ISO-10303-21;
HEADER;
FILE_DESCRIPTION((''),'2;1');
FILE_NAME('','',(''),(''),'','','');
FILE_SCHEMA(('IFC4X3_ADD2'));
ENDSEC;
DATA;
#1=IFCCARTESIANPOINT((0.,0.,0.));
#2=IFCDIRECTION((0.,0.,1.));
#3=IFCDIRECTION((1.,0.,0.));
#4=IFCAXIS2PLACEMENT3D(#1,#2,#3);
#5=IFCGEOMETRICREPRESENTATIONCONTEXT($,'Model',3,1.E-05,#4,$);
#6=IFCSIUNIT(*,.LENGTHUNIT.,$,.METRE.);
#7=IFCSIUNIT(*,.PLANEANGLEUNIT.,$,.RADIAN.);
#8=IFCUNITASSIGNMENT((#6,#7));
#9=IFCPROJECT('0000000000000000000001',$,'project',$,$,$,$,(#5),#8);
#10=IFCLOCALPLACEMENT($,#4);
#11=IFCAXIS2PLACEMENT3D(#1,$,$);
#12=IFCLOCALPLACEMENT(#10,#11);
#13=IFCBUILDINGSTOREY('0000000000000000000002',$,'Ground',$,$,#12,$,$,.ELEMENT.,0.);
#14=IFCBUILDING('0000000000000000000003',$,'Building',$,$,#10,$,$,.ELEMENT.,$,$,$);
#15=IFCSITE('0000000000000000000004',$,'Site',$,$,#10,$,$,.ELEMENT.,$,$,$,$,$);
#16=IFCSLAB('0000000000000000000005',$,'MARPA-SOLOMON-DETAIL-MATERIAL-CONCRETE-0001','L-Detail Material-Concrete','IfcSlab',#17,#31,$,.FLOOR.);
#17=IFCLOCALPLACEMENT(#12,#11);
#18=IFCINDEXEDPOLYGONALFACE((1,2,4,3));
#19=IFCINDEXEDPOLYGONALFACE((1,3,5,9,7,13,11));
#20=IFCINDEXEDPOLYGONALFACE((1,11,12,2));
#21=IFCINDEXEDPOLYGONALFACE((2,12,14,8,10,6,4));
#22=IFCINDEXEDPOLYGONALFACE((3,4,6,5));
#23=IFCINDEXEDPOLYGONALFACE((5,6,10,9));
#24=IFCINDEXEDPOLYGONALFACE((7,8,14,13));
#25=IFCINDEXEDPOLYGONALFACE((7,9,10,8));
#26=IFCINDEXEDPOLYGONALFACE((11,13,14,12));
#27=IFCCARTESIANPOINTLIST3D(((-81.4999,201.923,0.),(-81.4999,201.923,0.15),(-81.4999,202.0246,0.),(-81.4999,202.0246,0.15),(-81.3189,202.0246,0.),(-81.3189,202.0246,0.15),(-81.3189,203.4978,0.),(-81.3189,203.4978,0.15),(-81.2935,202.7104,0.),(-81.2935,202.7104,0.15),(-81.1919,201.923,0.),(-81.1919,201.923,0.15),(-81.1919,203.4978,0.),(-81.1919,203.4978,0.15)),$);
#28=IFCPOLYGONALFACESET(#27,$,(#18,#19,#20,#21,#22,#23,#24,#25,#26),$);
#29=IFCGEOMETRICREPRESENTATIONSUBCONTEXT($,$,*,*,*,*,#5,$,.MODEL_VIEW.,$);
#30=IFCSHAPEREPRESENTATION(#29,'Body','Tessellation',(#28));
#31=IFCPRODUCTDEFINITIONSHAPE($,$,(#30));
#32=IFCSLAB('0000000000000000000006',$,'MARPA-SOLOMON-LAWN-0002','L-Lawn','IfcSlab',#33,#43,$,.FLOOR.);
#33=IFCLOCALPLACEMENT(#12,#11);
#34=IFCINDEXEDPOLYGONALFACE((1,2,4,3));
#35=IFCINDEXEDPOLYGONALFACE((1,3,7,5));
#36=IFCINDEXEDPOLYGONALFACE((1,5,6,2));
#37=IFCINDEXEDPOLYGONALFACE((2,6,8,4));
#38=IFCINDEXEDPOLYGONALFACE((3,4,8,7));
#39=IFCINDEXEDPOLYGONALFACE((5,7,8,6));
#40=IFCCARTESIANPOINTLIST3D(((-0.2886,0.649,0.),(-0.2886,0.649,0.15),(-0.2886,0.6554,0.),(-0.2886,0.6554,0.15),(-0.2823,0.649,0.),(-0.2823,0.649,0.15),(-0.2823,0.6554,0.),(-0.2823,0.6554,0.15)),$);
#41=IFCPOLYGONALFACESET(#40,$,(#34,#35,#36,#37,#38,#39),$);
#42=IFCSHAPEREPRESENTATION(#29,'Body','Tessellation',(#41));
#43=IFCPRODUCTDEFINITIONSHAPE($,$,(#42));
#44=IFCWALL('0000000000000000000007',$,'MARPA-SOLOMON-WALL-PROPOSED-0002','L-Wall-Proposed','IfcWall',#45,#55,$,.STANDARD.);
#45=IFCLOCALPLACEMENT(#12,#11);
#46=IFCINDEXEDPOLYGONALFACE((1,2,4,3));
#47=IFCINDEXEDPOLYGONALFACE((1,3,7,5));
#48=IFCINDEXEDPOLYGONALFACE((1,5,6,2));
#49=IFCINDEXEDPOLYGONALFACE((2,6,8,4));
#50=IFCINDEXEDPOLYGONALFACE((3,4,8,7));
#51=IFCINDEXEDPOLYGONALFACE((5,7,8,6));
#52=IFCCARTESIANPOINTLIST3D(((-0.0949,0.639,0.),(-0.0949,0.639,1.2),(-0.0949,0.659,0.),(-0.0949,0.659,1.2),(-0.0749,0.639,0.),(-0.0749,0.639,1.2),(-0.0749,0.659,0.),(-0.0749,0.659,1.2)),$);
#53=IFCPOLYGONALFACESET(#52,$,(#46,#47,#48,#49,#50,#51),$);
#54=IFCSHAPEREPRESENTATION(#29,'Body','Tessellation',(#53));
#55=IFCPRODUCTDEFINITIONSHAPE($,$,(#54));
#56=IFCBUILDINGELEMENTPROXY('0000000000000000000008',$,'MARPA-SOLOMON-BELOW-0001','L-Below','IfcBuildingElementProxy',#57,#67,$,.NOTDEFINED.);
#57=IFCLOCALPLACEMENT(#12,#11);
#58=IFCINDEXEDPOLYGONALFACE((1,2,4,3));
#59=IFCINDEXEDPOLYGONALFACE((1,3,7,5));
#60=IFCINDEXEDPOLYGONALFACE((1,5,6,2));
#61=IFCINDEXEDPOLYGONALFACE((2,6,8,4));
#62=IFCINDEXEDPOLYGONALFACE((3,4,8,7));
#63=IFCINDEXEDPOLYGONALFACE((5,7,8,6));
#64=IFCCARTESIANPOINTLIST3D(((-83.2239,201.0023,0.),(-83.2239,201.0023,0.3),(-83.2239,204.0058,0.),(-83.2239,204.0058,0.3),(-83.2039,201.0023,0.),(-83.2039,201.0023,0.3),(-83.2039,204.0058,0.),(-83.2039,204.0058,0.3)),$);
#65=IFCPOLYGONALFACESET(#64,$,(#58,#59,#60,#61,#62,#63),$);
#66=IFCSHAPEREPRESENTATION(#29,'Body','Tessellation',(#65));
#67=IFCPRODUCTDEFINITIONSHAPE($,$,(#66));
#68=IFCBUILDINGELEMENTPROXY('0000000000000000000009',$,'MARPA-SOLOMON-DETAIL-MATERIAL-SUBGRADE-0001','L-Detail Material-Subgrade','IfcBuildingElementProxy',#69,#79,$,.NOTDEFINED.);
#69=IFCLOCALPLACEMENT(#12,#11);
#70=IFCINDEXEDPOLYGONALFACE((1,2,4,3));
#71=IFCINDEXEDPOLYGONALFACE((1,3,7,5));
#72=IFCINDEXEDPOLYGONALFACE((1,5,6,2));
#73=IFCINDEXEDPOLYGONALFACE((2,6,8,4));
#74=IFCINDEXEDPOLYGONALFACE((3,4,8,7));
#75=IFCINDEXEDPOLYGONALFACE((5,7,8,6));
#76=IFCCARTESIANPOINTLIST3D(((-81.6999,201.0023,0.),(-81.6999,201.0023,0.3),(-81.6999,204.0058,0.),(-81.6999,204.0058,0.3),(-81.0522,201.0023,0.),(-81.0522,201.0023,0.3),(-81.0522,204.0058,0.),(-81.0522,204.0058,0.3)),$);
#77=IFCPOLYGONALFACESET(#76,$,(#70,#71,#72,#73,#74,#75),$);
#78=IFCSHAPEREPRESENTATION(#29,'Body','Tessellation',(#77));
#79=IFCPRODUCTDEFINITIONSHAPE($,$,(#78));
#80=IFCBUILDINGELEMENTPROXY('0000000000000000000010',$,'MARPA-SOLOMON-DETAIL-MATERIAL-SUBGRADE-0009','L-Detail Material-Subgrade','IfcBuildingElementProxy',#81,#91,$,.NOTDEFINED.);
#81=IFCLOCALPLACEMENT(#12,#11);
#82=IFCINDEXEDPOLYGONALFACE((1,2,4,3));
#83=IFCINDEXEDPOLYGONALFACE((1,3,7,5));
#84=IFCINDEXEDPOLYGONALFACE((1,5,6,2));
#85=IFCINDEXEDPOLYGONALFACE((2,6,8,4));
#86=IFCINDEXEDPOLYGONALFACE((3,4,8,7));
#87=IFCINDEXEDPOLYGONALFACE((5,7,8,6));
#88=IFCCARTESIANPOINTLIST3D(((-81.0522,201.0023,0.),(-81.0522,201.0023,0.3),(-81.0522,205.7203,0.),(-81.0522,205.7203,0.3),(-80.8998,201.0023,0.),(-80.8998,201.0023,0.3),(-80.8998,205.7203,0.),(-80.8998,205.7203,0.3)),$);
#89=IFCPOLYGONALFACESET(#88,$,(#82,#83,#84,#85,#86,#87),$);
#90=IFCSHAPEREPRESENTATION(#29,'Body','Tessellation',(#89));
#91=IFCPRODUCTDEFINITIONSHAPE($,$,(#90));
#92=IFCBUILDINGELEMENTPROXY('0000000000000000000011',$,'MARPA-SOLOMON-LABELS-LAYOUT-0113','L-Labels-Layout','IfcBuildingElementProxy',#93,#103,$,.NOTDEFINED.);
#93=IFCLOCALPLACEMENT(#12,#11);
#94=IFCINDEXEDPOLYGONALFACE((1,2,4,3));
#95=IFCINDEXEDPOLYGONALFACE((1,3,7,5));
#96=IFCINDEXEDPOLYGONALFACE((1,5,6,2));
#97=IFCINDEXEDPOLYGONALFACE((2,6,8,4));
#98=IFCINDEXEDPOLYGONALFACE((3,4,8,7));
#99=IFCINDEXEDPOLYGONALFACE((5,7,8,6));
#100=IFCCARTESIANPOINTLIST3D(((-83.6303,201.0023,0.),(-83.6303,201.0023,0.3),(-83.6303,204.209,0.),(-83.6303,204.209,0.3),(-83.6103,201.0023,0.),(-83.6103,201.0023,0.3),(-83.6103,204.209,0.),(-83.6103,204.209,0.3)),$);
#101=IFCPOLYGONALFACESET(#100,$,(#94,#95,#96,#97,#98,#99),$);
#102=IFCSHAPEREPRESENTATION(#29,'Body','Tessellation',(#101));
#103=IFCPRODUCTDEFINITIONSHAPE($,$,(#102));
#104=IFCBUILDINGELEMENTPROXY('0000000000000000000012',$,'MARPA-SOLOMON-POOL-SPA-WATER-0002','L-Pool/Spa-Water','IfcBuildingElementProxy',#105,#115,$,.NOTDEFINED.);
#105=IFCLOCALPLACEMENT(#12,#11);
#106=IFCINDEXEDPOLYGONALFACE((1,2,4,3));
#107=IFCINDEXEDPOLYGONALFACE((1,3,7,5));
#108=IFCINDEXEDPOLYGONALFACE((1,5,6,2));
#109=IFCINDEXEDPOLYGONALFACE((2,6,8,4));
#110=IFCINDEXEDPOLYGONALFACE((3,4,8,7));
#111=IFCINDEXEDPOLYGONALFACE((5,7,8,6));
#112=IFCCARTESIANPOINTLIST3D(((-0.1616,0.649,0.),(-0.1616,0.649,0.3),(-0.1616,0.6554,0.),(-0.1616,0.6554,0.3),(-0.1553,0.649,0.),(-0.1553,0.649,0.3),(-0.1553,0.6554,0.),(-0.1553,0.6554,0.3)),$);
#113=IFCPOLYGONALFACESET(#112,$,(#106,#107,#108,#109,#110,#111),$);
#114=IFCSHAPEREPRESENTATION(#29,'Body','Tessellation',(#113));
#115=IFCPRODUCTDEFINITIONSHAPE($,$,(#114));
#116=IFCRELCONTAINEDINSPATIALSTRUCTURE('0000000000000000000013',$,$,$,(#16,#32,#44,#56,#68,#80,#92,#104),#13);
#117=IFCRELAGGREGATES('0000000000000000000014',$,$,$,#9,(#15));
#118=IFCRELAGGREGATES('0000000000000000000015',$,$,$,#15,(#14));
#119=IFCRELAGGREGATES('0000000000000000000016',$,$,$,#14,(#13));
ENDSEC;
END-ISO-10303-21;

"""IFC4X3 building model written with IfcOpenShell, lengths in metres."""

from ifc_helpers import new_model, si_unit, frame, frame_2d, origin, origin_with_axes, place, context, subcontext, project, spatial, polyline, rectangle, outline, extrude, element, save


model = new_model("IFC4X3")

# Units and contexts
model_context = context("Model", 3, precision=1e-05, world=origin_with_axes())
sub_context = subcontext(model_context, None, None, "MODEL_VIEW")
ifc_project = project(units=[si_unit("LENGTHUNIT", "METRE"), si_unit("PLANEANGLEUNIT", "RADIAN")], contexts=[model_context])

# Site, building, storey
placement = place(None, origin_with_axes())
site = spatial("IfcSite", under=ifc_project, at=placement, Name="Site", CompositionType="ELEMENT")
building = spatial("IfcBuilding", under=site, at=placement, Name="Building", CompositionType="ELEMENT")
storey_placement = place(placement, origin())
storey = spatial("IfcBuildingStorey", under=building, at=storey_placement, Name="Ground", CompositionType="ELEMENT", Elevation=0.0)

# Slabs
slab_placement = place(storey_placement, frame((-81.4999, 201.923, 0.0)))
element("IfcSlab", 1, at=slab_placement, inside=storey, Name="MARPA-SOLOMON-DETAIL-MATERIAL-CONCRETE-0001", Description="L-Detail Material-Concrete", ObjectType="IfcSlab", PredefinedType="FLOOR", context=sub_context, shape_type="SweptSolid", body=[
    extrude(outline(polyline([(0.181, 1.5748), (0.2064, 0.7874), (0.181, 0.1016), (0.0, 0.1016), (0.0, 0.0), (0.308, 0.0), (0.308, 1.5748), (0.181, 1.5748)])), origin(), (0.0, 0.0, 1.0), 0.15),
])
for number, where, name in (
    (2, (-0.2886, 0.649, 0.0), "MARPA-SOLOMON-LAWN-0002"),
):
    element("IfcSlab", number, at=place(storey_placement, frame(where)), inside=storey, Name=name, Description="L-Lawn", ObjectType="IfcSlab", PredefinedType="FLOOR", context=sub_context, shape_type="SweptSolid", body=[
        extrude(outline(polyline([(0.0, 0.0063), (0.0063, 0.0063), (0.0063, 0.0), (0.0, 0.0), (0.0, 0.0063)])), origin(), (0.0, 0.0, 1.0), 0.15),
    ])

# Wall
for number, where, x_axis, name in (
    (3, (-0.0949, 0.649, 0.0), (1.0, 0.0, 0.0), "MARPA-SOLOMON-WALL-PROPOSED-0002"),
):
    element("IfcWall", number, at=place(storey_placement, frame(where, x_axis=x_axis)), inside=storey, Name=name, Description="L-Wall-Proposed", ObjectType="IfcWall", PredefinedType="STANDARD", context=sub_context, shape_type="SweptSolid", body=[
        extrude(rectangle(XDim=0.02, YDim=0.02, at=frame_2d((0.01, 0.0))), origin(), (0.0, 0.0, 1.0), 1.2),
    ])

# Building element proxies
proxy_1_placement = place(placement, frame((-83.2239, 201.0023, 0.0)))
element("IfcBuildingElementProxy", 4, at=proxy_1_placement, inside=storey, Name="MARPA-SOLOMON-BELOW-0001", Description="L-Below", ObjectType="IfcBuildingElementProxy", PredefinedType="NOTDEFINED", context=sub_context, shape_type="SweptSolid", body=[
    extrude(rectangle(XDim=0.02, YDim=3.0036, at=frame_2d((0.01, 1.5018))), origin(), (0.0, 0.0, 1.0), 0.3),
])
proxy_2_placement = place(placement, frame((-81.6999, 201.0023, 0.0)))
element("IfcBuildingElementProxy", 5, at=proxy_2_placement, inside=storey, Name="MARPA-SOLOMON-DETAIL-MATERIAL-SUBGRADE-0001", Description="L-Detail Material-Subgrade", ObjectType="IfcBuildingElementProxy", PredefinedType="NOTDEFINED", context=sub_context, shape_type="SweptSolid", body=[
    extrude(rectangle(XDim=0.6477, YDim=3.0036, at=frame_2d((0.3239, 1.5018))), origin(), (0.0, 0.0, 1.0), 0.3),
])
proxy_3_placement = place(placement, frame((-81.0522, 201.0023, 0.0)))
element("IfcBuildingElementProxy", 6, at=proxy_3_placement, inside=storey, Name="MARPA-SOLOMON-DETAIL-MATERIAL-SUBGRADE-0009", Description="L-Detail Material-Subgrade", ObjectType="IfcBuildingElementProxy", PredefinedType="NOTDEFINED", context=sub_context, shape_type="SweptSolid", body=[
    extrude(outline(polyline([(0.0, 0.0), (0.0, 4.718), (0.1524, 4.718), (0.1524, 0.0), (0.0, 0.0)])), origin(), (0.0, 0.0, 1.0), 0.3),
])
proxy_4_placement = place(placement, frame((-83.6303, 201.0023, 0.0)))
element("IfcBuildingElementProxy", 7, at=proxy_4_placement, inside=storey, Name="MARPA-SOLOMON-LABELS-LAYOUT-0113", Description="L-Labels-Layout", ObjectType="IfcBuildingElementProxy", PredefinedType="NOTDEFINED", context=sub_context, shape_type="SweptSolid", body=[
    extrude(rectangle(XDim=0.02, YDim=3.2068, at=frame_2d((0.01, 1.6034))), origin(), (0.0, 0.0, 1.0), 0.3),
])
for number, where, name in (
    (8, (-0.1616, 0.649, 0.0), "MARPA-SOLOMON-POOL-SPA-WATER-0002"),
):
    element("IfcBuildingElementProxy", number, at=place(placement, frame(where)), inside=storey, Name=name, Description="L-Pool/Spa-Water", ObjectType="IfcBuildingElementProxy", PredefinedType="NOTDEFINED", context=sub_context, shape_type="SweptSolid", body=[
        extrude(outline(polyline([(0.0, 0.0063), (0.0063, 0.0063), (0.0063, 0.0), (0.0, 0.0), (0.0, 0.0063)])), origin(), (0.0, 0.0, 1.0), 0.3),
    ])

save(model, "model.ifc")
